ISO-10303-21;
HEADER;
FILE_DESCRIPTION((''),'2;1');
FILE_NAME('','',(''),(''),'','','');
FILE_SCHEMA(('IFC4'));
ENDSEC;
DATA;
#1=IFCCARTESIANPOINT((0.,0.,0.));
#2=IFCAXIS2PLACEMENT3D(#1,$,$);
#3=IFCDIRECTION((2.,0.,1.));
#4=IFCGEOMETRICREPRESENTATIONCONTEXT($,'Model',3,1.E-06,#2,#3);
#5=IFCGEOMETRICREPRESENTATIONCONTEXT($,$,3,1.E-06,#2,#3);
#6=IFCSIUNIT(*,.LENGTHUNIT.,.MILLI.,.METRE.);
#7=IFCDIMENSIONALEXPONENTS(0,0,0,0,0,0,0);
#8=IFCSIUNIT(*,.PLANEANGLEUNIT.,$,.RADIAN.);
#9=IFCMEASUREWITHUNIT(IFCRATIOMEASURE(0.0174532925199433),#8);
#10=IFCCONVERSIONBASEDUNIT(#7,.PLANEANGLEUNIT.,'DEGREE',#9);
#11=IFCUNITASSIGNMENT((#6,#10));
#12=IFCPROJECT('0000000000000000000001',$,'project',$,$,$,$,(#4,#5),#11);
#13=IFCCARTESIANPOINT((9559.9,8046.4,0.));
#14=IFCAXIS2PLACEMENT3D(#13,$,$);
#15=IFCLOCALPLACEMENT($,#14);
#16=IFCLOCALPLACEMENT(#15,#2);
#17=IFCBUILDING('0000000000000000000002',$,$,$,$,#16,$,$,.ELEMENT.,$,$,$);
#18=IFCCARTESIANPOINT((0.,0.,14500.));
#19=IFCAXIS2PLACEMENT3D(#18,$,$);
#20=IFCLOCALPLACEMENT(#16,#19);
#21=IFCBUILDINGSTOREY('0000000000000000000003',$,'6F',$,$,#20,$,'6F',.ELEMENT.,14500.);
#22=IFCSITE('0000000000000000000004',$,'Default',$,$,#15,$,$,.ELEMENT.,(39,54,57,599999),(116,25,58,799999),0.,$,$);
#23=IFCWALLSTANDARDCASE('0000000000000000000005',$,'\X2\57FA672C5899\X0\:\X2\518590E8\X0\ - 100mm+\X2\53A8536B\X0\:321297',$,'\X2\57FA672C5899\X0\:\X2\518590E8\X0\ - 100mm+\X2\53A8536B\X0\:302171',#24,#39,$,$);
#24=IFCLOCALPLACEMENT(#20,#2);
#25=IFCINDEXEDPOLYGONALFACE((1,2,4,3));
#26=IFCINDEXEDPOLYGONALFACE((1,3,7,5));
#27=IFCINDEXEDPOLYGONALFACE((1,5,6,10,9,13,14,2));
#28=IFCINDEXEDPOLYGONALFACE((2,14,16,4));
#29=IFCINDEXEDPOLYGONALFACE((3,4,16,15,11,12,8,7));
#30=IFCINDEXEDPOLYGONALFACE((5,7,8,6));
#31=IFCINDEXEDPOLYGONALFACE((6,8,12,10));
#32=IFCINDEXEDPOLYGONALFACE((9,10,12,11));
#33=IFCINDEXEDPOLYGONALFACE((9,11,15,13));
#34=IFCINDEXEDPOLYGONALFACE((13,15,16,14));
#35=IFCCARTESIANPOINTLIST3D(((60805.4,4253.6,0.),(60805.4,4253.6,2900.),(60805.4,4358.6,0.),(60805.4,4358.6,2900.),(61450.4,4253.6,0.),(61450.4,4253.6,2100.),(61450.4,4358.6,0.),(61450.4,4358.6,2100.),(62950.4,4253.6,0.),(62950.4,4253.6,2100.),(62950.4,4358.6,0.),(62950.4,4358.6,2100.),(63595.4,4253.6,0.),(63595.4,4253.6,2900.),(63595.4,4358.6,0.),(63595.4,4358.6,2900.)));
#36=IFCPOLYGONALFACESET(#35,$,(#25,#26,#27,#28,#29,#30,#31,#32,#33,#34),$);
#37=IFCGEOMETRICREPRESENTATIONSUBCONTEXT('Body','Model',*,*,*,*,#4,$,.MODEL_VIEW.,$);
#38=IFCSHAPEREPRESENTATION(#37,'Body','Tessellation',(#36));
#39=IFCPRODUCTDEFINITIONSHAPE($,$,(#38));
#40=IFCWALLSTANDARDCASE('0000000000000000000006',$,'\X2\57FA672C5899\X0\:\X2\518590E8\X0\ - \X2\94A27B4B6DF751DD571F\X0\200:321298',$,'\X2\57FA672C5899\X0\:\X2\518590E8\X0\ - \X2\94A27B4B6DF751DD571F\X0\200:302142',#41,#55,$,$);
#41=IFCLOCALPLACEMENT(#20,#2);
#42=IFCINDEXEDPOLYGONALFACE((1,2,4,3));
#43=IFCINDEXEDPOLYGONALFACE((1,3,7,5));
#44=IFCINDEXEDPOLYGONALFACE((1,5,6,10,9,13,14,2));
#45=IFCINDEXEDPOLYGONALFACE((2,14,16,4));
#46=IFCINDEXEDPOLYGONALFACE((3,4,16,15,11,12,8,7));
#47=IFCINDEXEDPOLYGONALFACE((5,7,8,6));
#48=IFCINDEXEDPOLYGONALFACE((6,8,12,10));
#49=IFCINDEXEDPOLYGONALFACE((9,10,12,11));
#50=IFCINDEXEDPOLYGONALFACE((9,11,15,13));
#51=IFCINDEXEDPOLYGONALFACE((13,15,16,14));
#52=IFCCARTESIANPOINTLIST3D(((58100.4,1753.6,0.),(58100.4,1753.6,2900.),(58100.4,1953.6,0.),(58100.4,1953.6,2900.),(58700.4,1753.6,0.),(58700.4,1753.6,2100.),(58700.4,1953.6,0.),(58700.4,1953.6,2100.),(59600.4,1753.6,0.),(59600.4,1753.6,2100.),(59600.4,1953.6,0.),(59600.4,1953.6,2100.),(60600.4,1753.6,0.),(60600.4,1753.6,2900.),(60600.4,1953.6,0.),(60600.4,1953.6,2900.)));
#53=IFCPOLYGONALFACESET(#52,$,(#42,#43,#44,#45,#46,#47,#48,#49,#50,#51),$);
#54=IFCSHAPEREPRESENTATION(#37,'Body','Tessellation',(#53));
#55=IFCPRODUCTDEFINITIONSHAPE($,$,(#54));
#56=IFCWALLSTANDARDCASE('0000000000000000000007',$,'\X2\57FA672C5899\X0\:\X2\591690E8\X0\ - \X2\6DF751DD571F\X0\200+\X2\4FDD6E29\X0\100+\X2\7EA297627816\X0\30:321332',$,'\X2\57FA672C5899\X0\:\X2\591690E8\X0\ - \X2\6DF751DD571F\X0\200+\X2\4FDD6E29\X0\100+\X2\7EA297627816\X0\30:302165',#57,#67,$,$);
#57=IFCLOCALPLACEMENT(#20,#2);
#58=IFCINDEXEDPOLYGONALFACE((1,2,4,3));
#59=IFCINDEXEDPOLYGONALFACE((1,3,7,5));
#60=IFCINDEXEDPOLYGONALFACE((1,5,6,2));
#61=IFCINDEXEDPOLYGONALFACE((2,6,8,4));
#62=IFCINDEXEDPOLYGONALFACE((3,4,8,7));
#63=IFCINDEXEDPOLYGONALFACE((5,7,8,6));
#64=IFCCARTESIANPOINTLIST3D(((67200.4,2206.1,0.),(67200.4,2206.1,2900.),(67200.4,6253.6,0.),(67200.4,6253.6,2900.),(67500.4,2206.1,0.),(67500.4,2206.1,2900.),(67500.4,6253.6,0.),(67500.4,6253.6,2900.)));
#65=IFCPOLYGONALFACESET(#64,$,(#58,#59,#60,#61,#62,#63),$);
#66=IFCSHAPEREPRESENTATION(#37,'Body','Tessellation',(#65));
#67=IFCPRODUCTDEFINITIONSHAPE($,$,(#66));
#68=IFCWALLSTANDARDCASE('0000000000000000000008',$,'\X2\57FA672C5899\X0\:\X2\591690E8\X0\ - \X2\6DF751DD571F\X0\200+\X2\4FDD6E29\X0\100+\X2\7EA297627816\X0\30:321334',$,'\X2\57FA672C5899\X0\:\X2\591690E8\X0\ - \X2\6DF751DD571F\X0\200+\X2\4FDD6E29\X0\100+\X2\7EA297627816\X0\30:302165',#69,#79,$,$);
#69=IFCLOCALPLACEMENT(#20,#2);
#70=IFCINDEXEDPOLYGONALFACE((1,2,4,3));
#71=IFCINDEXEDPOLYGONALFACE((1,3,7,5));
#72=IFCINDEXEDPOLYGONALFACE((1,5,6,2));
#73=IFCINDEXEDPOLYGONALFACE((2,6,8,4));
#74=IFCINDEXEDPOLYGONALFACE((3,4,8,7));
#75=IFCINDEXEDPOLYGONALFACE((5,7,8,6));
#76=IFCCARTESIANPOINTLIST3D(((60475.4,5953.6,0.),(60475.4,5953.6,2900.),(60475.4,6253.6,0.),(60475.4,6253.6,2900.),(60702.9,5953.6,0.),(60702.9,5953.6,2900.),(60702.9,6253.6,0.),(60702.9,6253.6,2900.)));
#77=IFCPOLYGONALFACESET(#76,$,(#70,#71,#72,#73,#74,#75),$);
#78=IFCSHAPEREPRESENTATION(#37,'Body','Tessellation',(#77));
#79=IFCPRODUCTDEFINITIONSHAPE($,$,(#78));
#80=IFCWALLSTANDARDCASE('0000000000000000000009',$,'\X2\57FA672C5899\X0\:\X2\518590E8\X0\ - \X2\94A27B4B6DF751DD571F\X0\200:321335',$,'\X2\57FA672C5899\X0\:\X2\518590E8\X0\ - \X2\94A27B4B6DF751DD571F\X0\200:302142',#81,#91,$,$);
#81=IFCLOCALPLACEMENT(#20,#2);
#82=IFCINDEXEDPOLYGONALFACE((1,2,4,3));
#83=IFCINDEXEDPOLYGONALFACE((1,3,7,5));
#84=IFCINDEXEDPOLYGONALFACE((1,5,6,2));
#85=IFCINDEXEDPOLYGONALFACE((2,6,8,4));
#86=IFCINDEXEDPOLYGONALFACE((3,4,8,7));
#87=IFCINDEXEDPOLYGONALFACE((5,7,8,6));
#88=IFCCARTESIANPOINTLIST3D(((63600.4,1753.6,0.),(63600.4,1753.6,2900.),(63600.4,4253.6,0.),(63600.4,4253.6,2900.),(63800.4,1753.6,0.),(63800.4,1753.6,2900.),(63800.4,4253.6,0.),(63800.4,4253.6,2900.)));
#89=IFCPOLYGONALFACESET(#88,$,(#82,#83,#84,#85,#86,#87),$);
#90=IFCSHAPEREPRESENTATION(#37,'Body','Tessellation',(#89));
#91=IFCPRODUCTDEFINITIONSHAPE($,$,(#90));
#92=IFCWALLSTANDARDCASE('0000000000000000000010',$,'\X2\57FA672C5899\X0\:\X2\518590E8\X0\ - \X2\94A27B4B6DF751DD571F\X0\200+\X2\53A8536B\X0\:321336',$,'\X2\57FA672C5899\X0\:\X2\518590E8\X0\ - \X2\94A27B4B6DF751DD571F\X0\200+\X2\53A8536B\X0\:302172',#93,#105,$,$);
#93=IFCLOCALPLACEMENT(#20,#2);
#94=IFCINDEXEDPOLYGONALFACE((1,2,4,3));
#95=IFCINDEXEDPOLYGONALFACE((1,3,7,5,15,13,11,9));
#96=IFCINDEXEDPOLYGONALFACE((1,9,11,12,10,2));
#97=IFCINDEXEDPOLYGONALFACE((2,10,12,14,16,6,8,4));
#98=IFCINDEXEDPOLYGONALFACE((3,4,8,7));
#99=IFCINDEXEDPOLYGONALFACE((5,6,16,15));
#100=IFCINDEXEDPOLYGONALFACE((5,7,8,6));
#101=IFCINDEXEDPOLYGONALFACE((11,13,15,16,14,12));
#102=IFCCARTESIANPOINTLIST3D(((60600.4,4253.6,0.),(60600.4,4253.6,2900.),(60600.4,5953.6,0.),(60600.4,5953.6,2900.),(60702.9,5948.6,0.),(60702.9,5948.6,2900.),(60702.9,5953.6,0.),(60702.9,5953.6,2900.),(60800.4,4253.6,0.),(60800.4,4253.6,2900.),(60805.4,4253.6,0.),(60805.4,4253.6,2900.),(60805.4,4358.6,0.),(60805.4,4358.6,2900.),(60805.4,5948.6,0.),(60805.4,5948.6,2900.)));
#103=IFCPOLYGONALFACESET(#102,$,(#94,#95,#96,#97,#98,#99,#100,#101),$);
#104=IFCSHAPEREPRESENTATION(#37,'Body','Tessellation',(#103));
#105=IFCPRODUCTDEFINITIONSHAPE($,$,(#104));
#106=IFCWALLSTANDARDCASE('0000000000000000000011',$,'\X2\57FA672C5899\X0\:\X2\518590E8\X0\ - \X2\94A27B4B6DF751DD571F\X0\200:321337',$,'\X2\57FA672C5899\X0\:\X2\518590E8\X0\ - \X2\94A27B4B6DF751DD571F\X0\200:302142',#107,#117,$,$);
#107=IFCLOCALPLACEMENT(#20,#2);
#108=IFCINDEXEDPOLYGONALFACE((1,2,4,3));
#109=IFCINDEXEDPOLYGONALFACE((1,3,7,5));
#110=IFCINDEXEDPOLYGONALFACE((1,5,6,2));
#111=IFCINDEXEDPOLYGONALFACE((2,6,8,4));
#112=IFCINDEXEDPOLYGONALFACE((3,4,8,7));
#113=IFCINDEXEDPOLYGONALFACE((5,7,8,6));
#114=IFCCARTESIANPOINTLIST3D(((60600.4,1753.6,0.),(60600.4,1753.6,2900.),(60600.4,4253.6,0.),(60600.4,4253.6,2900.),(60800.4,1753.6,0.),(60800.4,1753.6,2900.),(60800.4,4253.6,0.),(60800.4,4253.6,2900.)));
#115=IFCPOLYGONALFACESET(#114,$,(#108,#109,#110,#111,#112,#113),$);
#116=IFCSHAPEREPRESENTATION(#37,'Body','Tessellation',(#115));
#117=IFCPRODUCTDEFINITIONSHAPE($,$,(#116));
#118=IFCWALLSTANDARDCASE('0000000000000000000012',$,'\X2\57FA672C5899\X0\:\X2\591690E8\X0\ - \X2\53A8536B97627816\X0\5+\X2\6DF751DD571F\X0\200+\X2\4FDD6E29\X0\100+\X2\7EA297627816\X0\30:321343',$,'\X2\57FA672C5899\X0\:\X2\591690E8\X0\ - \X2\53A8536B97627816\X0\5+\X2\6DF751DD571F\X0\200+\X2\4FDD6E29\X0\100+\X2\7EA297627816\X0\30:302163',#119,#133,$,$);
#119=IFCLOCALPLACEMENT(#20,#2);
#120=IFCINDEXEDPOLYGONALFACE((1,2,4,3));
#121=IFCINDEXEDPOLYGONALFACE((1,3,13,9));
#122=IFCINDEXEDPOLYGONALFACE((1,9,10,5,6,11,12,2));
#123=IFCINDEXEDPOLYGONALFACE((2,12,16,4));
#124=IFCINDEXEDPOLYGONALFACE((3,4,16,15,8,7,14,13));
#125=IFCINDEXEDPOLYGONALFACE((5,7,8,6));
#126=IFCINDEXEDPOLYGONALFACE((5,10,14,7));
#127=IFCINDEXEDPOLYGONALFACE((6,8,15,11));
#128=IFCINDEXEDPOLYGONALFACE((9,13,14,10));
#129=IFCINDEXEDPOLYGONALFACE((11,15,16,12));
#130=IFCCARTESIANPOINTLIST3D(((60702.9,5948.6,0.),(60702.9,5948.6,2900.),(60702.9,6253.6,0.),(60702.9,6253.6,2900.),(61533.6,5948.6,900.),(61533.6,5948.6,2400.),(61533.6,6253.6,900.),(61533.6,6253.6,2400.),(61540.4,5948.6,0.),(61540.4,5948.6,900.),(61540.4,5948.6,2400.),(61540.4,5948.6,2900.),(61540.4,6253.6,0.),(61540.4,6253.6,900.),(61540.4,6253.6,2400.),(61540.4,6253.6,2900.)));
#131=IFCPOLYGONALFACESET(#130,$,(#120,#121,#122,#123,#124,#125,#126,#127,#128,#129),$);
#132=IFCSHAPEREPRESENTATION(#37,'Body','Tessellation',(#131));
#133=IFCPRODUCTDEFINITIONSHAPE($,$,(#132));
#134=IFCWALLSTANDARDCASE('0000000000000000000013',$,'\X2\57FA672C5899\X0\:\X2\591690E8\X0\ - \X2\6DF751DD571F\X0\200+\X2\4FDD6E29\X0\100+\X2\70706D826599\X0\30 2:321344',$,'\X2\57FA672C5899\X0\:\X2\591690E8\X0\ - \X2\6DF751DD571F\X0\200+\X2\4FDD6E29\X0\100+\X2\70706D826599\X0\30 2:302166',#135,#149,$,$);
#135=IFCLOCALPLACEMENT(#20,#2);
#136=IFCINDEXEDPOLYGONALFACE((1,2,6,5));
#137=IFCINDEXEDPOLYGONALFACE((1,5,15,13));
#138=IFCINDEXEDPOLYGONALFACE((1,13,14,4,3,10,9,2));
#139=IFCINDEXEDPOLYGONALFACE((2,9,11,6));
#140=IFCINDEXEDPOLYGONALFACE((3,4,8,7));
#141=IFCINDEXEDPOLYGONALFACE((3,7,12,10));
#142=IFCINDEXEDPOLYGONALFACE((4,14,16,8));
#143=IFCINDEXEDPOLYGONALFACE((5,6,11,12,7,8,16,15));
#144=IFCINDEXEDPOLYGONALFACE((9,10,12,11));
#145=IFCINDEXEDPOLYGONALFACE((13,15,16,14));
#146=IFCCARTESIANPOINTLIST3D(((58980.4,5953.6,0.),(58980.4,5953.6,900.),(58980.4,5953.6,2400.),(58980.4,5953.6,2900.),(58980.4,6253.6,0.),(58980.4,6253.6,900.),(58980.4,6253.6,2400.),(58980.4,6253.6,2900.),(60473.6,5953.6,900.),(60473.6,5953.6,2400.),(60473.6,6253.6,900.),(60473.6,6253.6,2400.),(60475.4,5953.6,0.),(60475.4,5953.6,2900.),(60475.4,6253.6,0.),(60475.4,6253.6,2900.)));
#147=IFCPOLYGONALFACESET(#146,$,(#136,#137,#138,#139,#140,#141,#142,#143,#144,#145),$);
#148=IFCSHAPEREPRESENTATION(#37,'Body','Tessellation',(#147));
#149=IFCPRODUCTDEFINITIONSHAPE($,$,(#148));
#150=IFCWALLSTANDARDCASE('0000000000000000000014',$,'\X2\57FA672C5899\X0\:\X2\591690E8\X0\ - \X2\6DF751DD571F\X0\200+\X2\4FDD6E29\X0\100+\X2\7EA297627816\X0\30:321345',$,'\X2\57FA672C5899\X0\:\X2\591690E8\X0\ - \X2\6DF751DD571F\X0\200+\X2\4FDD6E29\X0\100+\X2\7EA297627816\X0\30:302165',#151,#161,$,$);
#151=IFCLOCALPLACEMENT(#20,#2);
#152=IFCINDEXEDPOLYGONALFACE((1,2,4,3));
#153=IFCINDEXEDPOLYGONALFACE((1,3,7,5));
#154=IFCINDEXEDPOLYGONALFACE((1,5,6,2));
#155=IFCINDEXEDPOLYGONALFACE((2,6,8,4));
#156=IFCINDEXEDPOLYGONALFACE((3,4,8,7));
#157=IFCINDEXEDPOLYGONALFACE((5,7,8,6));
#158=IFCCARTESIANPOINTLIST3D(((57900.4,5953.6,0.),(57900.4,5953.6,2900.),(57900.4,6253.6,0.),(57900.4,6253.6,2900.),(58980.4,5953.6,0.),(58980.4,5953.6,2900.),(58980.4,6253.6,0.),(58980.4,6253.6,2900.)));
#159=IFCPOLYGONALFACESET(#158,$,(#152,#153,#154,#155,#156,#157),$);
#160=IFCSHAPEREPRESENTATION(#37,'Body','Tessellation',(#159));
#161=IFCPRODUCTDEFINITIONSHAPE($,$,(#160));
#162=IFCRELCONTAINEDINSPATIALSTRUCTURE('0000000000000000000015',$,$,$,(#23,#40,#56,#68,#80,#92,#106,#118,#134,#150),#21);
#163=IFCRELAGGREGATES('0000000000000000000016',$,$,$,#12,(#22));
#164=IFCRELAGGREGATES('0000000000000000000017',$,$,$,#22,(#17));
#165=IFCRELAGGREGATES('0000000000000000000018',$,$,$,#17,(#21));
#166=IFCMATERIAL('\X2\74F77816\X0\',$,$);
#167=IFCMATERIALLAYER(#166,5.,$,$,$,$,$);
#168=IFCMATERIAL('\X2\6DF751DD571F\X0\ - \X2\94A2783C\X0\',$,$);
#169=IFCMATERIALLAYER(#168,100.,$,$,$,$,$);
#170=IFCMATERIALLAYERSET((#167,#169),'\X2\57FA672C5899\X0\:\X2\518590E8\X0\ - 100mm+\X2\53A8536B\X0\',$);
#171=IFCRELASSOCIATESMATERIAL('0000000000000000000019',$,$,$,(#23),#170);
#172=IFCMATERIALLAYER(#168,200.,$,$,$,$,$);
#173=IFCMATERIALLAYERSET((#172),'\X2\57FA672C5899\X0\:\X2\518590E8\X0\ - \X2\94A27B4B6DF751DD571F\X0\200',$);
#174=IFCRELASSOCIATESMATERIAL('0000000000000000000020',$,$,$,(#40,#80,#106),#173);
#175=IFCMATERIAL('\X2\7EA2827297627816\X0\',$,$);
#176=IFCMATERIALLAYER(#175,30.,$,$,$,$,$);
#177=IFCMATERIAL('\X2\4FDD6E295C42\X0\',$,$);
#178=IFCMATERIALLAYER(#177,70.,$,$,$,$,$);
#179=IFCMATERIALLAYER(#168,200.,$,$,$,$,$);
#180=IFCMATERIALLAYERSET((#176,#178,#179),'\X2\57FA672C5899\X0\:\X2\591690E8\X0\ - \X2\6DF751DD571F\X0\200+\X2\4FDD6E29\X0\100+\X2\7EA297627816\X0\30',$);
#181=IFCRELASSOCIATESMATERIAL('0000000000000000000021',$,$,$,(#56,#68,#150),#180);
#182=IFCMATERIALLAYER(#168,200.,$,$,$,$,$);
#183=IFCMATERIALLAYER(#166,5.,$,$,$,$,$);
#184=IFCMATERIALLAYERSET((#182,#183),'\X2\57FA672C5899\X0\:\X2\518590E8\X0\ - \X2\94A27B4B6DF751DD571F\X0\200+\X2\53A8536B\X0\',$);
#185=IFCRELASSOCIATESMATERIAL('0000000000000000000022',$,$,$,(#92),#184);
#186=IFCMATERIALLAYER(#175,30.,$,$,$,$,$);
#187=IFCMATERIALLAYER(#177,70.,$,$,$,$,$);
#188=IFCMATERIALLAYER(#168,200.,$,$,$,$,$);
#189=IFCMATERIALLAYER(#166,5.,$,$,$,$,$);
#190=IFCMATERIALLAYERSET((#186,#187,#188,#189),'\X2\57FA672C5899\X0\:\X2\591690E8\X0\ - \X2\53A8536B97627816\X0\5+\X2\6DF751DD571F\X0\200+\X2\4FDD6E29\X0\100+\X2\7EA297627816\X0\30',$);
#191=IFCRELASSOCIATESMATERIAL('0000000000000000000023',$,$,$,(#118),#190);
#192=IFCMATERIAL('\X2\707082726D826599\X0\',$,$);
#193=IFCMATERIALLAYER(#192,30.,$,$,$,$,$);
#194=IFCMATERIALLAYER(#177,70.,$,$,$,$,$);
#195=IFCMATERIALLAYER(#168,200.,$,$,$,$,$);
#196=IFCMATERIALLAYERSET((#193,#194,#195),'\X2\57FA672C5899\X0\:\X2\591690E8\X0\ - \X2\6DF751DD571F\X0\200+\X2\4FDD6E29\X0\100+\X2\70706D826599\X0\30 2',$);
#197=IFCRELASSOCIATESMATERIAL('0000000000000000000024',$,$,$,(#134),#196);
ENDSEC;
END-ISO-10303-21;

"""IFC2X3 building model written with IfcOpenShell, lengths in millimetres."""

from ifc_helpers import new_model, entity, si_unit, converted_unit, direction, frame, frame_2d, origin, place, context, subcontext, project, spatial, polyline, rectangle, outline, extrude, material, layer, layer_set, layer_usage, element, save


model = new_model("IFC2X3")

# Units and contexts
model_context = context("Model", 3, precision=1e-06, world=origin(), true_north=direction((2.0, 0.0, 1.0)))
context_of_model = context(None, 3, precision=1e-06, world=origin(), true_north=direction((2.0, 0.0, 1.0)))
body_context = subcontext(model_context, "Body", "Model", "MODEL_VIEW")
ifc_project = project(units=[si_unit("LENGTHUNIT", "METRE", prefix="MILLI"), converted_unit("PLANEANGLEUNIT", "DEGREE", entity("IfcRatioMeasure", 0.0174532925199433), si_unit("PLANEANGLEUNIT", "RADIAN"), dimensions=[0, 0, 0, 0, 0, 0, 0])], contexts=[model_context, context_of_model])

# Site, building, storey
site_placement = place(None, frame((9559.9, 8046.4, 0.0)))
site = spatial("IfcSite", under=ifc_project, at=site_placement, Name="Default", CompositionType="ELEMENT", RefLatitude=(39, 54, 57, 599999), RefLongitude=(116, 25, 58, 799999), RefElevation=0.0)
building_placement = place(site_placement, origin())
building = spatial("IfcBuilding", under=site, at=building_placement, CompositionType="ELEMENT")
storey_placement = place(building_placement, frame((0.0, 0.0, 14500.0)))
storey = spatial("IfcBuildingStorey", under=building, at=storey_placement, Name="6F", LongName="6F", CompositionType="ELEMENT", Elevation=14500.0)

# Shared definitions
ifc_material_1 = material(Name="红色面砖")
ifc_layer_1 = layer(ifc_material_1, 30.0)
ifc_material_2 = material(Name="保温层")
ifc_layer_2 = layer(ifc_material_2, 70.0)
ifc_material_3 = material(Name="混凝土 - 钢砼")
ifc_layer_3 = layer(ifc_material_3, 200.0)
ifc_layer_set_1 = layer_set([ifc_layer_1, ifc_layer_2, ifc_layer_3], Name="基本墙:外部 - 混凝土200+保温100+红面砖30")

# Shared definitions
ifc_layer_4 = layer(ifc_material_3, 200.0)
ifc_material_4 = material(Name="瓷砖")
ifc_layer_5 = layer(ifc_material_4, 5.0)
ifc_layer_set_2 = layer_set([ifc_layer_4, ifc_layer_5], Name="基本墙:内部 - 钢筋混凝土200+厨卫")

# Shared definitions
ifc_layer_6 = layer(ifc_material_3, 200.0)
ifc_layer_set_3 = layer_set([ifc_layer_6], Name="基本墙:内部 - 钢筋混凝土200")

# Shared definitions
ifc_layer_7 = layer(ifc_material_4, 5.0)
ifc_layer_8 = layer(ifc_material_3, 100.0)
ifc_layer_set_4 = layer_set([ifc_layer_7, ifc_layer_8], Name="基本墙:内部 - 100mm+厨卫")

# Walls, openings
ifc_layer_usage_1 = layer_usage(ifc_layer_set_4, "AXIS2", "POSITIVE", -52.5)
wall_1_placement = place(storey_placement, frame((63595.4, 4306.1, 0.0), z_axis=(0.0, 0.0, 1.0), x_axis=(-1.0, 0.0, 0.0)))
wall_1 = element("IfcWallStandardCase", 1, at=wall_1_placement, inside=storey, material=ifc_layer_usage_1, Name="基本墙:内部 - 100mm+厨卫:321297", ObjectType="基本墙:内部 - 100mm+厨卫:302171", context=body_context, shape_type="SweptSolid", body=[
    extrude(rectangle(XDim=2790.0, YDim=105.0, at=frame_2d((1395.0, 0.0), x_axis=(-1.0, 0.0))), origin(), (0.0, 0.0, 1.0), 2900.0),
])
opening_1_placement = place(wall_1_placement, frame((645.0, -52.5, 0.0)))
element("IfcOpeningElement", 2, at=opening_1_placement, cuts=wall_1, ObjectType="Opening", context=body_context, shape_type="SweptSolid", body=[
    extrude(rectangle(XDim=2100.0, YDim=1500.0, at=frame_2d((1050.0, 750.0), x_axis=(1.0, 0.0))), frame((0.0, 0.0, 0.0), z_axis=(0.0, 1.0, 0.0), x_axis=(0.0, 0.0, 1.0)), (0.0, 0.0, 1.0), 105.0),
])
ifc_layer_usage_2 = layer_usage(ifc_layer_set_3, "AXIS2", "POSITIVE", -100.0)
wall_2_placement = place(storey_placement, frame((60600.4, 1853.6, 0.0), z_axis=(0.0, 0.0, 1.0), x_axis=(-1.0, 0.0, 0.0)))
wall_2 = element("IfcWallStandardCase", 3, at=wall_2_placement, inside=storey, material=ifc_layer_usage_2, Name="基本墙:内部 - 钢筋混凝土200:321298", ObjectType="基本墙:内部 - 钢筋混凝土200:302142", context=body_context, shape_type="SweptSolid", body=[
    extrude(rectangle(XDim=2500.0, YDim=200.0, at=frame_2d((1250.0, 0.0), x_axis=(-1.0, 0.0))), origin(), (0.0, 0.0, 1.0), 2900.0),
])
opening_2_placement = place(wall_2_placement, frame((1900.0, 100.0, 0.0)))
element("IfcOpeningElement", 4, at=opening_2_placement, cuts=wall_2, ObjectType="Opening", context=body_context, shape_type="SweptSolid", body=[
    extrude(rectangle(XDim=2100.0, YDim=900.0, at=frame_2d((1050.0, 450.0), x_axis=(1.0, 0.0))), frame((0.0, 0.0, 0.0), z_axis=(0.0, -1.0, 0.0), x_axis=(0.0, 0.0, 1.0)), (0.0, 0.0, 1.0), 200.0),
])

# Walls
ifc_layer_usage_3 = layer_usage(ifc_layer_set_1, "AXIS2", "POSITIVE", -150.0)
wall_3_placement = place(storey_placement, frame((67350.4, 2206.1, 0.0), z_axis=(0.0, 0.0, 1.0), x_axis=(0.0, 1.0, 0.0)))
element("IfcWallStandardCase", 5, at=wall_3_placement, inside=storey, material=ifc_layer_usage_3, Name="基本墙:外部 - 混凝土200+保温100+红面砖30:321332", ObjectType="基本墙:外部 - 混凝土200+保温100+红面砖30:302165", context=body_context, shape_type="SweptSolid", body=[
    extrude(rectangle(XDim=4047.5, YDim=300.0, at=frame_2d((2023.8, 0.0), x_axis=(-1.0, 0.0))), origin(), (0.0, 0.0, 1.0), 2900.0),
])
ifc_layer_usage_4 = layer_usage(ifc_layer_set_1, "AXIS2", "POSITIVE", -150.0)
wall_4_placement = place(storey_placement, frame((60702.9, 6103.6, 0.0), z_axis=(0.0, 0.0, 1.0), x_axis=(-1.0, 0.0, 0.0)))
element("IfcWallStandardCase", 6, at=wall_4_placement, inside=storey, material=ifc_layer_usage_4, Name="基本墙:外部 - 混凝土200+保温100+红面砖30:321334", ObjectType="基本墙:外部 - 混凝土200+保温100+红面砖30:302165", context=body_context, shape_type="SweptSolid", body=[
    extrude(rectangle(XDim=227.5, YDim=300.0, at=frame_2d((113.8, 0.0), x_axis=(-1.0, 0.0))), origin(), (0.0, 0.0, 1.0), 2900.0),
])
ifc_layer_usage_5 = layer_usage(ifc_layer_set_3, "AXIS2", "POSITIVE", -100.0)
wall_5_placement = place(storey_placement, frame((63700.4, 4253.6, 0.0), z_axis=(0.0, 0.0, 1.0), x_axis=(0.0, -1.0, 0.0)))
element("IfcWallStandardCase", 7, at=wall_5_placement, inside=storey, material=ifc_layer_usage_5, Name="基本墙:内部 - 钢筋混凝土200:321335", ObjectType="基本墙:内部 - 钢筋混凝土200:302142", context=body_context, shape_type="SweptSolid", body=[
    extrude(rectangle(XDim=2500.0, YDim=200.0, at=frame_2d((1250.0, 0.0), x_axis=(-1.0, 0.0))), origin(), (0.0, 0.0, 1.0), 2900.0),
])
ifc_layer_usage_6 = layer_usage(ifc_layer_set_2, "AXIS2", "POSITIVE", -102.5)
wall_6_placement = place(storey_placement, frame((60702.9, 5953.6, 0.0), z_axis=(0.0, 0.0, 1.0), x_axis=(0.0, -1.0, 0.0)))
element("IfcWallStandardCase", 8, at=wall_6_placement, inside=storey, material=ifc_layer_usage_6, Name="基本墙:内部 - 钢筋混凝土200+厨卫:321336", ObjectType="基本墙:内部 - 钢筋混凝土200+厨卫:302172", context=body_context, shape_type="SweptSolid", body=[
    extrude(outline(polyline([(1700.0, -102.5), (1700.0, 97.5), (1700.0, 102.5), (1595.0, 102.5), (5.0, 102.5), (5.0, 0.0), (0.0, 0.0), (0.0, -102.5), (1700.0, -102.5)])), origin(), (0.0, 0.0, 1.0), 2900.0),
])
ifc_layer_usage_7 = layer_usage(ifc_layer_set_3, "AXIS2", "POSITIVE", -100.0)
wall_7_placement = place(storey_placement, frame((60700.4, 4253.6, 0.0), z_axis=(0.0, 0.0, 1.0), x_axis=(0.0, -1.0, 0.0)))
element("IfcWallStandardCase", 9, at=wall_7_placement, inside=storey, material=ifc_layer_usage_7, Name="基本墙:内部 - 钢筋混凝土200:321337", ObjectType="基本墙:内部 - 钢筋混凝土200:302142", context=body_context, shape_type="SweptSolid", body=[
    extrude(rectangle(XDim=2500.0, YDim=200.0, at=frame_2d((1250.0, 0.0), x_axis=(-1.0, 0.0))), origin(), (0.0, 0.0, 1.0), 2900.0),
])

# Walls, openings
ifc_layer_9 = layer(ifc_material_1, 30.0)
ifc_layer_10 = layer(ifc_material_2, 70.0)
ifc_layer_11 = layer(ifc_material_3, 200.0)
ifc_layer_12 = layer(ifc_material_4, 5.0)
ifc_layer_set_5 = layer_set([ifc_layer_9, ifc_layer_10, ifc_layer_11, ifc_layer_12], Name="基本墙:外部 - 厨卫面砖5+混凝土200+保温100+红面砖30")
ifc_layer_usage_8 = layer_usage(ifc_layer_set_5, "AXIS2", "POSITIVE", -152.5)
wall_8_placement = place(storey_placement, frame((61540.4, 6101.1, 0.0), z_axis=(0.0, 0.0, 1.0), x_axis=(-1.0, 0.0, 0.0)))
wall_8 = element("IfcWallStandardCase", 10, at=wall_8_placement, inside=storey, material=ifc_layer_usage_8, Name="基本墙:外部 - 厨卫面砖5+混凝土200+保温100+红面砖30:321343", ObjectType="基本墙:外部 - 厨卫面砖5+混凝土200+保温100+红面砖30:302163", context=body_context, shape_type="SweptSolid", body=[
    extrude(rectangle(XDim=837.5, YDim=305.0, at=frame_2d((418.8, 0.0), x_axis=(-1.0, 0.0))), origin(), (0.0, 0.0, 1.0), 2900.0),
])
opening_3_placement = place(wall_8_placement, frame((6.7, 152.5, 900.0)))
element("IfcOpeningElement", 11, at=opening_3_placement, cuts=wall_8, ObjectType="Opening", context=body_context, shape_type="SweptSolid", body=[
    extrude(rectangle(XDim=1500.0, YDim=1800.0, at=frame_2d((750.0, 900.0), x_axis=(1.0, 0.0))), frame((0.0, 0.0, 0.0), z_axis=(0.0, -1.0, 0.0), x_axis=(0.0, 0.0, 1.0)), (0.0, 0.0, 1.0), 305.0),
])
ifc_material_5 = material(Name="灰色涂料")
ifc_layer_13 = layer(ifc_material_5, 30.0)
ifc_layer_14 = layer(ifc_material_2, 70.0)
ifc_layer_15 = layer(ifc_material_3, 200.0)
ifc_layer_set_6 = layer_set([ifc_layer_13, ifc_layer_14, ifc_layer_15], Name="基本墙:外部 - 混凝土200+保温100+灰涂料30 2")
ifc_layer_usage_9 = layer_usage(ifc_layer_set_6, "AXIS2", "POSITIVE", -150.0)
wall_9_placement = place(storey_placement, frame((60475.4, 6103.6, 0.0), z_axis=(0.0, 0.0, 1.0), x_axis=(-1.0, 0.0, 0.0)))
wall_9 = element("IfcWallStandardCase", 12, at=wall_9_placement, inside=storey, material=ifc_layer_usage_9, Name="基本墙:外部 - 混凝土200+保温100+灰涂料30 2:321344", ObjectType="基本墙:外部 - 混凝土200+保温100+灰涂料30 2:302166", context=body_context, shape_type="SweptSolid", body=[
    extrude(rectangle(XDim=1495.0, YDim=300.0, at=frame_2d((747.5, 0.0), x_axis=(-1.0, 0.0))), origin(), (0.0, 0.0, 1.0), 2900.0),
])
opening_4_placement = place(wall_9_placement, frame((1501.7, 150.0, 900.0)))
element("IfcOpeningElement", 13, at=opening_4_placement, cuts=wall_9, ObjectType="Opening", context=body_context, shape_type="SweptSolid", body=[
    extrude(rectangle(XDim=1500.0, YDim=1500.0, at=frame_2d((750.0, 750.0), x_axis=(1.0, 0.0))), frame((0.0, 0.0, 0.0), z_axis=(0.0, -1.0, 0.0), x_axis=(0.0, 0.0, 1.0)), (0.0, 0.0, 1.0), 300.0),
])

# Wall
ifc_layer_usage_10 = layer_usage(ifc_layer_set_1, "AXIS2", "POSITIVE", -150.0)
wall_10_placement = place(storey_placement, frame((58980.4, 6103.6, 0.0), z_axis=(0.0, 0.0, 1.0), x_axis=(-1.0, 0.0, 0.0)))
element("IfcWallStandardCase", 14, at=wall_10_placement, inside=storey, material=ifc_layer_usage_10, Name="基本墙:外部 - 混凝土200+保温100+红面砖30:321345", ObjectType="基本墙:外部 - 混凝土200+保温100+红面砖30:302165", context=body_context, shape_type="SweptSolid", body=[
    extrude(rectangle(XDim=1080.0, YDim=300.0, at=frame_2d((540.0, 0.0), x_axis=(-1.0, 0.0))), origin(), (0.0, 0.0, 1.0), 2900.0),
])

save(model, "model.ifc")
